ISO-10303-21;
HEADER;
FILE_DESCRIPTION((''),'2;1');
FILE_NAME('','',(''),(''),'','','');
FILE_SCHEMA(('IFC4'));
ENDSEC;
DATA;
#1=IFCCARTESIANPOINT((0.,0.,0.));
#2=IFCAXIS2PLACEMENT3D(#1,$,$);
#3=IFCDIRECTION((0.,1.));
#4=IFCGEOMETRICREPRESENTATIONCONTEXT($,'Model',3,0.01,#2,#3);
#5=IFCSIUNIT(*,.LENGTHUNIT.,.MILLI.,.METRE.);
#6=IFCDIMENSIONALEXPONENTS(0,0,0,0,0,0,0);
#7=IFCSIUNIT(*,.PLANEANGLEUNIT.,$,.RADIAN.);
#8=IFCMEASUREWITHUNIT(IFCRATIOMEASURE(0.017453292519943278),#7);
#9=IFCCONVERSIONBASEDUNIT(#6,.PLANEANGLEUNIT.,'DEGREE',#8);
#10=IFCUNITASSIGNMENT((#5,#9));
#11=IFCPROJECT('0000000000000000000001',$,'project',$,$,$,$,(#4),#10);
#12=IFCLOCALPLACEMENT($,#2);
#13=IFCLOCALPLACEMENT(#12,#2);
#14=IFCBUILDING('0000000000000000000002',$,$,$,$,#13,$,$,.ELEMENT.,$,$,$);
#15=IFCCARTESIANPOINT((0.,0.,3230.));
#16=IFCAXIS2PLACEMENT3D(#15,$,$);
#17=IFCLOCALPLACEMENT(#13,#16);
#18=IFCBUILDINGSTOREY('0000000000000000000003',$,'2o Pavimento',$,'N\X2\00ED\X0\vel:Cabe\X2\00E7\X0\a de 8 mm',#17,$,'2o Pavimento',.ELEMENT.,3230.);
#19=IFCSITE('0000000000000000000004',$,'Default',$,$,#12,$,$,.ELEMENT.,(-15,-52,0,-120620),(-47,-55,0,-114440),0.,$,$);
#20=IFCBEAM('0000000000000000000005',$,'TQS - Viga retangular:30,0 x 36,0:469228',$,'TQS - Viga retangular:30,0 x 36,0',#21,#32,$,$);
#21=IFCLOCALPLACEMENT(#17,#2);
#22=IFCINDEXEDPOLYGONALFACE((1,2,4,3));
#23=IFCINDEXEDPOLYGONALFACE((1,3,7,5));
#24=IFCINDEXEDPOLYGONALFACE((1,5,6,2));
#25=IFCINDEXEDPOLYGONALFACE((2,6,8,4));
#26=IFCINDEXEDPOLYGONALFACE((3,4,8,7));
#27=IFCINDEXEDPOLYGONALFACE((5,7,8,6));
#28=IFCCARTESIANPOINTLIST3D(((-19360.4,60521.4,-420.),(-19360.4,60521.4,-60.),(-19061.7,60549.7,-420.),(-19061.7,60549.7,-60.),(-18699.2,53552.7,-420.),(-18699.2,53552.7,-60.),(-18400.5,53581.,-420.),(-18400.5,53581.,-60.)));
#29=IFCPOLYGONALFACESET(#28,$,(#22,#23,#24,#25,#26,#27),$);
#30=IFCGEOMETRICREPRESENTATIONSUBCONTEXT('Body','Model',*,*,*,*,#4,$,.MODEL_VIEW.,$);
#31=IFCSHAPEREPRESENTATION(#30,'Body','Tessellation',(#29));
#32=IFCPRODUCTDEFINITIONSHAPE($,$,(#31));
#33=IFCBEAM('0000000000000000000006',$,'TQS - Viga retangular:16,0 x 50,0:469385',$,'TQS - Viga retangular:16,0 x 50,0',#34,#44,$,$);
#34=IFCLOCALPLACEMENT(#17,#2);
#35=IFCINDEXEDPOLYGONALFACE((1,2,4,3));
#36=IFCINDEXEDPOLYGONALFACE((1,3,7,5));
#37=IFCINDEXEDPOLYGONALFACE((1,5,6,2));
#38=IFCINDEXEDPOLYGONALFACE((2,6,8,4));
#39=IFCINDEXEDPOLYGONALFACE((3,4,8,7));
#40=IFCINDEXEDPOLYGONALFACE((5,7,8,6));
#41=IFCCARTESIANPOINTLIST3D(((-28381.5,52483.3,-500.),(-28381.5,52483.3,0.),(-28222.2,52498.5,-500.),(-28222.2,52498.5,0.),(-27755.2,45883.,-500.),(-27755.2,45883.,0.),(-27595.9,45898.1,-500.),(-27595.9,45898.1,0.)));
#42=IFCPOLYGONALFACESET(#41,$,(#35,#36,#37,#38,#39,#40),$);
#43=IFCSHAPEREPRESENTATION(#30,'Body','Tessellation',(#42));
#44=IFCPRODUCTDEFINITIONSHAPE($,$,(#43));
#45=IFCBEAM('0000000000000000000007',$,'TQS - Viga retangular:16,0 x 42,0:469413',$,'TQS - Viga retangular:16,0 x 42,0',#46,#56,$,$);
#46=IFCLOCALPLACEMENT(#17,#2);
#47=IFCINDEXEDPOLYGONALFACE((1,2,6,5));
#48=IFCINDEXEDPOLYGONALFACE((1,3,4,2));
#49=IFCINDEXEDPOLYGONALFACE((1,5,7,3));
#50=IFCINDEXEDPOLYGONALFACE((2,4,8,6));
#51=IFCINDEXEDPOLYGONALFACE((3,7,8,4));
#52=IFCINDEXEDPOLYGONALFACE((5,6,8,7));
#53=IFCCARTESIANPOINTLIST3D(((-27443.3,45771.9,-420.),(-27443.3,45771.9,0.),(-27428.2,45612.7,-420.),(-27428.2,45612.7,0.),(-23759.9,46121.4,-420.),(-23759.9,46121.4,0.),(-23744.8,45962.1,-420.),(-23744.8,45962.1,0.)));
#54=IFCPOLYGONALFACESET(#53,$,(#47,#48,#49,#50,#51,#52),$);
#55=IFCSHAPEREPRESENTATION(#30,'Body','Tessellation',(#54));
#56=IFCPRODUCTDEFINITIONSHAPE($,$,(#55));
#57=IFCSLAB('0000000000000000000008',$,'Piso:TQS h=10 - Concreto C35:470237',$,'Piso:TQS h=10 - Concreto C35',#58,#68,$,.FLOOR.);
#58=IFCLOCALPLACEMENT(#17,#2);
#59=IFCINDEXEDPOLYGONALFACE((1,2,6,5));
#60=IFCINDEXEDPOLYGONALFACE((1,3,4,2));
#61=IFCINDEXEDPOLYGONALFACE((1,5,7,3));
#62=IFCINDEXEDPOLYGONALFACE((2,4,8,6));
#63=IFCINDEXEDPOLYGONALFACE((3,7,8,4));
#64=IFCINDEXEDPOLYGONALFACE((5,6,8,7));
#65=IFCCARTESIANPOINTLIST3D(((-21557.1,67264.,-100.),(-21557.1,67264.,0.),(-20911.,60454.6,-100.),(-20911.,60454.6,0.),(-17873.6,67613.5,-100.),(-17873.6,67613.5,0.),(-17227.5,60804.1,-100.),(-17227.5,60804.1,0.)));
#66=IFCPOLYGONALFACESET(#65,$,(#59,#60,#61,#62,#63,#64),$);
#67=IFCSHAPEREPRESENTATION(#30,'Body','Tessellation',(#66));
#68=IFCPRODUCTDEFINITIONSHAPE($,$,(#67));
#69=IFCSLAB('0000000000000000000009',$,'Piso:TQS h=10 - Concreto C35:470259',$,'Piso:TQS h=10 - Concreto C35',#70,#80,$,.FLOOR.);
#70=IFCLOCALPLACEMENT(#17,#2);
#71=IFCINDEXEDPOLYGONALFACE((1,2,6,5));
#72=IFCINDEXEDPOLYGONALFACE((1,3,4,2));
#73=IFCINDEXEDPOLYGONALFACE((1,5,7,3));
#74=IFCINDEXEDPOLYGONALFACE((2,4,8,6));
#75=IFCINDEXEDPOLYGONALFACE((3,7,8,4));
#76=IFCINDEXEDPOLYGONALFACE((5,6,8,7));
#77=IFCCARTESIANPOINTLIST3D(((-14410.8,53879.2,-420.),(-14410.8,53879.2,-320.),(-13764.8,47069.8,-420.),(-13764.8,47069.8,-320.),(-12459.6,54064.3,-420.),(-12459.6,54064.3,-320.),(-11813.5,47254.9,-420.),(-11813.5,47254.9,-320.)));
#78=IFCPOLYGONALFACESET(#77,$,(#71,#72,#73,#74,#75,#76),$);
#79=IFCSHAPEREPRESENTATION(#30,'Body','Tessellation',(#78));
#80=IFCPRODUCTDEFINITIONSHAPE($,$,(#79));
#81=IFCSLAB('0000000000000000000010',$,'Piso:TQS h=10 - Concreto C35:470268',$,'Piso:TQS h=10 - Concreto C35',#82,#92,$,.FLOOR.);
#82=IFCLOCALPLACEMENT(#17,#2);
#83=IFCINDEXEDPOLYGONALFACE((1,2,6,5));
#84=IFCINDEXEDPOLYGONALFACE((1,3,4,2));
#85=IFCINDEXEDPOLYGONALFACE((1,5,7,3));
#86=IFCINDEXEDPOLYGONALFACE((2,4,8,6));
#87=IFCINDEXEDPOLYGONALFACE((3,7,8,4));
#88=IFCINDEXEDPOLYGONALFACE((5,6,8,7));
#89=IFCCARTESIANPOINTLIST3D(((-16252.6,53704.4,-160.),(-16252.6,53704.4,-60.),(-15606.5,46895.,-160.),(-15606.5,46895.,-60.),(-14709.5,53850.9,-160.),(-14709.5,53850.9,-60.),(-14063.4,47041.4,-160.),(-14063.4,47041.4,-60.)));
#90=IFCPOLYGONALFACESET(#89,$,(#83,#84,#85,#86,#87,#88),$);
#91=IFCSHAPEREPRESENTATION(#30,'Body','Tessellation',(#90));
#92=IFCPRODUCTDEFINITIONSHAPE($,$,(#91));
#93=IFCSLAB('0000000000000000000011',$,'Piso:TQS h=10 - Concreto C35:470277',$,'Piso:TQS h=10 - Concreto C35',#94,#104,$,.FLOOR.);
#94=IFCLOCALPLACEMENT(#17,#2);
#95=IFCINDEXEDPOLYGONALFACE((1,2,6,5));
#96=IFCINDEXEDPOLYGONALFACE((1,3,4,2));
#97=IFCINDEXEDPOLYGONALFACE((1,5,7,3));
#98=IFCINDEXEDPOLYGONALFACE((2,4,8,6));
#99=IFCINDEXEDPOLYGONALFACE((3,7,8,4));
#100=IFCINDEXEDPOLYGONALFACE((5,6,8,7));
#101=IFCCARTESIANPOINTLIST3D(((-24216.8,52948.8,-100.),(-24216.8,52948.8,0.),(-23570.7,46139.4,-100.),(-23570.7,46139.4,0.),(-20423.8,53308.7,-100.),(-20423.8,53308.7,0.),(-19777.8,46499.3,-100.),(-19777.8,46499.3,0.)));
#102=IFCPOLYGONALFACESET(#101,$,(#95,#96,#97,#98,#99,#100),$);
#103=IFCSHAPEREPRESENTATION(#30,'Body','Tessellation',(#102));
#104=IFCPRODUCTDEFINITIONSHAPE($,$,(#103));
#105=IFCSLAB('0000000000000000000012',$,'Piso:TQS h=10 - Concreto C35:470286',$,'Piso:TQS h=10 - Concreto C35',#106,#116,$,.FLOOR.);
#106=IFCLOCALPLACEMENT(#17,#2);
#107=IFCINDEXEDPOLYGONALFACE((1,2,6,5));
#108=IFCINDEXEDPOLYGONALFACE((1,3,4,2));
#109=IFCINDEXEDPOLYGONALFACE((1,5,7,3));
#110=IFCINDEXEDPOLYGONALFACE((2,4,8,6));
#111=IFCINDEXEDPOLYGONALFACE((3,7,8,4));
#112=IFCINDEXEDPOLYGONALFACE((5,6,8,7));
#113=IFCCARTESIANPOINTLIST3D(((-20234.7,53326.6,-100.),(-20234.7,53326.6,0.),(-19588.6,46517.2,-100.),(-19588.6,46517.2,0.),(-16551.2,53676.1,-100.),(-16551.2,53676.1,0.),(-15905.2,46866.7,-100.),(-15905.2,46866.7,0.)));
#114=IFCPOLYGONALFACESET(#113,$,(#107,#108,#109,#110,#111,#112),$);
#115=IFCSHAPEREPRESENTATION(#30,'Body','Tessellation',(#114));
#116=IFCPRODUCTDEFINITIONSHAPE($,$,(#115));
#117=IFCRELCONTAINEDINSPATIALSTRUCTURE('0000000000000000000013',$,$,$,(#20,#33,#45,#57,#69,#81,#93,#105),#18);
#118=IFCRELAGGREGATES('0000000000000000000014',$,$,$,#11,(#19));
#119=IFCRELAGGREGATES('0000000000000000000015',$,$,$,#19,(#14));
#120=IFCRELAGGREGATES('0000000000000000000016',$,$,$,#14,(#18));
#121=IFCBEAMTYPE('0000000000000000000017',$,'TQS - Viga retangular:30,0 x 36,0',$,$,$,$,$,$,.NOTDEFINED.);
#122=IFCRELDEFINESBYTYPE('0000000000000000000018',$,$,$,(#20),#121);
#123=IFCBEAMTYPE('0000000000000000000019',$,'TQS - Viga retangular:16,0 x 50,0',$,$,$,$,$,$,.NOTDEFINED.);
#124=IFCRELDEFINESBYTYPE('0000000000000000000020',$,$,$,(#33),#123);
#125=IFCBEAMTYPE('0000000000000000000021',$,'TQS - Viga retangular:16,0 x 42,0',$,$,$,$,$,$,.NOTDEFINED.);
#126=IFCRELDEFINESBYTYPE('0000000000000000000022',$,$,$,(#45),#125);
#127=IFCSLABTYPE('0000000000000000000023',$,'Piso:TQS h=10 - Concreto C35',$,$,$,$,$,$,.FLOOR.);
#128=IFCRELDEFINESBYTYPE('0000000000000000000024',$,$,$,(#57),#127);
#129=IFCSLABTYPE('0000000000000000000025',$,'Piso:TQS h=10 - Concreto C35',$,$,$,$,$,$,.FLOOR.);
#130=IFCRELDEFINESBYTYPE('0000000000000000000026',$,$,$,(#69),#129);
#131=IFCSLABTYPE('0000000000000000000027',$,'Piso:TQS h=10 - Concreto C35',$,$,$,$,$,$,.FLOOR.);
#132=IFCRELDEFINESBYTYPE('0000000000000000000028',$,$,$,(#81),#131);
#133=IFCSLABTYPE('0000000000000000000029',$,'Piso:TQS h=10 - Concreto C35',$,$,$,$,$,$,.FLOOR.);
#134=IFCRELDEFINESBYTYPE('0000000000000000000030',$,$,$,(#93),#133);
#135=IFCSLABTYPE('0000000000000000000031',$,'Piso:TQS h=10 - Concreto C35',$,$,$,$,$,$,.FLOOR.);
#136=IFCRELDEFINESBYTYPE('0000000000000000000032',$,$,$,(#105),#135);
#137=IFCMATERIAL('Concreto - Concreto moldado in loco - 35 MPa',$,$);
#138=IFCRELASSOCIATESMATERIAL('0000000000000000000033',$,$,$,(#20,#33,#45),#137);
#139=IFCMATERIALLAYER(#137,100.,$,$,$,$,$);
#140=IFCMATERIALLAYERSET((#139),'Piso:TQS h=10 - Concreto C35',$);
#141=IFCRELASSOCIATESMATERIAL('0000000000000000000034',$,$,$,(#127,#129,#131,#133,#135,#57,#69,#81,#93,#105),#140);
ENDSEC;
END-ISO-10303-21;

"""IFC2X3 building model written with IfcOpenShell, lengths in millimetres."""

from ifc_helpers import new_model, entity, si_unit, converted_unit, direction, frame, frame_2d, origin, origin_2d_with_axis, place, context, subcontext, project, spatial, rectangle, extrude, material, layer, layer_set, layer_usage, type_object, element, save


model = new_model("IFC2X3")

# Units and contexts
model_context = context("Model", 3, precision=0.01, world=origin(), true_north=direction((0.0, 1.0)))
body_context = subcontext(model_context, "Body", "Model", "MODEL_VIEW")
ifc_project = project(units=[si_unit("LENGTHUNIT", "METRE", prefix="MILLI"), converted_unit("PLANEANGLEUNIT", "DEGREE", entity("IfcRatioMeasure", 0.017453292519943278), si_unit("PLANEANGLEUNIT", "RADIAN"), dimensions=[0, 0, 0, 0, 0, 0, 0])], contexts=[model_context])

# Site, building, storey
site_placement = place(None, origin())
site = spatial("IfcSite", under=ifc_project, at=site_placement, Name="Default", CompositionType="ELEMENT", RefLatitude=(-15, -52, 0, -120620), RefLongitude=(-47, -55, 0, -114440), RefElevation=0.0)
building_placement = place(site_placement, origin())
building = spatial("IfcBuilding", under=site, at=building_placement, CompositionType="ELEMENT")
storey_placement = place(building_placement, frame((0.0, 0.0, 3230.0)))
storey = spatial("IfcBuildingStorey", under=building, at=storey_placement, Name="2o Pavimento", ObjectType="Nível:Cabeça de 8 mm", LongName="2o Pavimento", CompositionType="ELEMENT", Elevation=3230.0)

# Beams
ifc_material = material(Name="Concreto - Concreto moldado in loco - 35 MPa")
beam_type_1 = type_object("IfcBeamType", Name="TQS - Viga retangular:30,0 x 36,0", PredefinedType="NOTDEFINED")
beam_1_placement = place(storey_placement, frame((-18549.8, 53566.8, -60.0), z_axis=(0.0, 0.0, 1.0), x_axis=(-0.094456, 0.995529, 0.0)))
element("IfcBeam", 1, at=beam_1_placement, inside=storey, type_object=beam_type_1, material=ifc_material, Name="TQS - Viga retangular:30,0 x 36,0:469228", ObjectType="TQS - Viga retangular:30,0 x 36,0", context=body_context, shape_type="SweptSolid", body=[
    extrude(rectangle(XDim=360.0, YDim=300.0, at=frame_2d((0.0, 0.0), x_axis=(1.0, 0.0))), frame((0.0, 0.0, -180.0), z_axis=(1.0, 0.0, 0.0), x_axis=(0.0, 0.0, -1.0)), (0.0, 0.0, 1.0), 7000.0),
])
beam_type_2 = type_object("IfcBeamType", Name="TQS - Viga retangular:16,0 x 50,0", PredefinedType="NOTDEFINED")
beam_2_placement = place(storey_placement, frame((-27675.6, 45890.5, 0.0), z_axis=(0.0, 0.0, 1.0), x_axis=(-0.094456, 0.995529, 0.0)))
element("IfcBeam", 2, at=beam_2_placement, inside=storey, type_object=beam_type_2, material=ifc_material, Name="TQS - Viga retangular:16,0 x 50,0:469385", ObjectType="TQS - Viga retangular:16,0 x 50,0", context=body_context, shape_type="SweptSolid", body=[
    extrude(rectangle(XDim=500.0, YDim=160.0, at=origin_2d_with_axis()), frame((0.0, 0.0, -250.0), z_axis=(1.0, 0.0, 0.0), x_axis=(0.0, 0.0, -1.0)), (0.0, 0.0, 1.0), 6630.0),
])
beam_type_3 = type_object("IfcBeamType", Name="TQS - Viga retangular:16,0 x 42,0", PredefinedType="NOTDEFINED")
beam_3_placement = place(storey_placement, frame((-23657.7, 46050.8, 0.0), z_axis=(0.0, 0.0, 1.0), x_axis=(-0.995529, -0.094456, 0.0)))
element("IfcBeam", 3, at=beam_3_placement, inside=storey, type_object=beam_type_3, material=ifc_material, Name="TQS - Viga retangular:16,0 x 42,0:469413", ObjectType="TQS - Viga retangular:16,0 x 42,0", context=body_context, shape_type="SweptSolid", body=[
    extrude(rectangle(XDim=420.0, YDim=160.0, at=origin_2d_with_axis()), frame((95.0, 0.0, -210.0), z_axis=(1.0, 0.0, 0.0), x_axis=(0.0, 0.0, -1.0)), (0.0, 0.0, 1.0), 3700.0),
])

# Slabs
ifc_layer = layer(ifc_material, 100.0)
ifc_layer_set = layer_set([ifc_layer], Name="Piso:TQS h=10 - Concreto C35")
ifc_layer_usage_1 = layer_usage(ifc_layer_set, "AXIS3", "POSITIVE", 0.0)
slab_type_1 = type_object("IfcSlabType", Name="Piso:TQS h=10 - Concreto C35", PredefinedType="FLOOR", material=ifc_layer_set)
slab_1_placement = place(storey_placement, origin())
element("IfcSlab", 4, at=slab_1_placement, inside=storey, type_object=slab_type_1, material=ifc_layer_usage_1, Name="Piso:TQS h=10 - Concreto C35:470237", ObjectType="Piso:TQS h=10 - Concreto C35", PredefinedType="FLOOR", context=body_context, shape_type="SweptSolid", body=[
    extrude(rectangle(XDim=6840.0, YDim=3700.0, at=frame_2d((0.0, 0.0), x_axis=(1.0, 0.0))), frame((-19392.3, 64034.1, 0.0), z_axis=(0.0, 0.0, -1.0), x_axis=(0.094456, -0.995529, 0.0)), (0.0, 0.0, 1.0), 100.0),
])
ifc_layer_usage_2 = layer_usage(ifc_layer_set, "AXIS3", "POSITIVE", 0.0)
slab_type_2 = type_object("IfcSlabType", Name="Piso:TQS h=10 - Concreto C35", PredefinedType="FLOOR", material=ifc_layer_set)
slab_2_placement = place(storey_placement, origin())
element("IfcSlab", 5, at=slab_2_placement, inside=storey, type_object=slab_type_2, material=ifc_layer_usage_2, Name="Piso:TQS h=10 - Concreto C35:470259", ObjectType="Piso:TQS h=10 - Concreto C35", PredefinedType="FLOOR", context=body_context, shape_type="SweptSolid", body=[
    extrude(rectangle(XDim=6840.0, YDim=1960.0, at=frame_2d((0.0, 0.0), x_axis=(1.0, 0.0))), frame((-13112.2, 50567.0, -320.0), z_axis=(0.0, 0.0, -1.0), x_axis=(0.094456, -0.995529, 0.0)), (0.0, 0.0, 1.0), 100.0),
])
ifc_layer_usage_3 = layer_usage(ifc_layer_set, "AXIS3", "POSITIVE", 0.0)
slab_type_3 = type_object("IfcSlabType", Name="Piso:TQS h=10 - Concreto C35", PredefinedType="FLOOR", material=ifc_layer_set)
slab_3_placement = place(storey_placement, origin())
element("IfcSlab", 6, at=slab_3_placement, inside=storey, type_object=slab_type_3, material=ifc_layer_usage_3, Name="Piso:TQS h=10 - Concreto C35:470268", ObjectType="Piso:TQS h=10 - Concreto C35", PredefinedType="FLOOR", context=body_context, shape_type="SweptSolid", body=[
    extrude(rectangle(XDim=1550.0, YDim=6840.0, at=frame_2d((0.0, 0.0), x_axis=(1.0, 0.0))), frame((-15158.0, 50372.9, -60.0), z_axis=(0.0, 0.0, -1.0), x_axis=(0.995529, 0.094456, 0.0)), (0.0, 0.0, 1.0), 100.0),
])
ifc_layer_usage_4 = layer_usage(ifc_layer_set, "AXIS3", "POSITIVE", 0.0)
slab_type_4 = type_object("IfcSlabType", Name="Piso:TQS h=10 - Concreto C35", PredefinedType="FLOOR", material=ifc_layer_set)
slab_4_placement = place(storey_placement, origin())
element("IfcSlab", 7, at=slab_4_placement, inside=storey, type_object=slab_type_4, material=ifc_layer_usage_4, Name="Piso:TQS h=10 - Concreto C35:470277", ObjectType="Piso:TQS h=10 - Concreto C35", PredefinedType="FLOOR", context=body_context, shape_type="SweptSolid", body=[
    extrude(rectangle(XDim=3810.0, YDim=6840.0, at=frame_2d((0.0, 0.0), x_axis=(1.0, 0.0))), frame((-21997.3, 49724.0, 0.0), z_axis=(0.0, 0.0, -1.0), x_axis=(0.995529, 0.094456, 0.0)), (0.0, 0.0, 1.0), 100.0),
])
ifc_layer_usage_5 = layer_usage(ifc_layer_set, "AXIS3", "POSITIVE", 0.0)
slab_type_5 = type_object("IfcSlabType", Name="Piso:TQS h=10 - Concreto C35", PredefinedType="FLOOR", material=ifc_layer_set)
slab_5_placement = place(storey_placement, origin())
element("IfcSlab", 8, at=slab_5_placement, inside=storey, type_object=slab_type_5, material=ifc_layer_usage_5, Name="Piso:TQS h=10 - Concreto C35:470286", ObjectType="Piso:TQS h=10 - Concreto C35", PredefinedType="FLOOR", context=body_context, shape_type="SweptSolid", body=[
    extrude(rectangle(XDim=6840.0, YDim=3700.0, at=frame_2d((0.0, 0.0), x_axis=(1.0, 0.0))), frame((-18069.9, 50096.7, 0.0), z_axis=(0.0, 0.0, -1.0), x_axis=(0.094456, -0.995529, 0.0)), (0.0, 0.0, 1.0), 100.0),
])

save(model, "model.ifc")
